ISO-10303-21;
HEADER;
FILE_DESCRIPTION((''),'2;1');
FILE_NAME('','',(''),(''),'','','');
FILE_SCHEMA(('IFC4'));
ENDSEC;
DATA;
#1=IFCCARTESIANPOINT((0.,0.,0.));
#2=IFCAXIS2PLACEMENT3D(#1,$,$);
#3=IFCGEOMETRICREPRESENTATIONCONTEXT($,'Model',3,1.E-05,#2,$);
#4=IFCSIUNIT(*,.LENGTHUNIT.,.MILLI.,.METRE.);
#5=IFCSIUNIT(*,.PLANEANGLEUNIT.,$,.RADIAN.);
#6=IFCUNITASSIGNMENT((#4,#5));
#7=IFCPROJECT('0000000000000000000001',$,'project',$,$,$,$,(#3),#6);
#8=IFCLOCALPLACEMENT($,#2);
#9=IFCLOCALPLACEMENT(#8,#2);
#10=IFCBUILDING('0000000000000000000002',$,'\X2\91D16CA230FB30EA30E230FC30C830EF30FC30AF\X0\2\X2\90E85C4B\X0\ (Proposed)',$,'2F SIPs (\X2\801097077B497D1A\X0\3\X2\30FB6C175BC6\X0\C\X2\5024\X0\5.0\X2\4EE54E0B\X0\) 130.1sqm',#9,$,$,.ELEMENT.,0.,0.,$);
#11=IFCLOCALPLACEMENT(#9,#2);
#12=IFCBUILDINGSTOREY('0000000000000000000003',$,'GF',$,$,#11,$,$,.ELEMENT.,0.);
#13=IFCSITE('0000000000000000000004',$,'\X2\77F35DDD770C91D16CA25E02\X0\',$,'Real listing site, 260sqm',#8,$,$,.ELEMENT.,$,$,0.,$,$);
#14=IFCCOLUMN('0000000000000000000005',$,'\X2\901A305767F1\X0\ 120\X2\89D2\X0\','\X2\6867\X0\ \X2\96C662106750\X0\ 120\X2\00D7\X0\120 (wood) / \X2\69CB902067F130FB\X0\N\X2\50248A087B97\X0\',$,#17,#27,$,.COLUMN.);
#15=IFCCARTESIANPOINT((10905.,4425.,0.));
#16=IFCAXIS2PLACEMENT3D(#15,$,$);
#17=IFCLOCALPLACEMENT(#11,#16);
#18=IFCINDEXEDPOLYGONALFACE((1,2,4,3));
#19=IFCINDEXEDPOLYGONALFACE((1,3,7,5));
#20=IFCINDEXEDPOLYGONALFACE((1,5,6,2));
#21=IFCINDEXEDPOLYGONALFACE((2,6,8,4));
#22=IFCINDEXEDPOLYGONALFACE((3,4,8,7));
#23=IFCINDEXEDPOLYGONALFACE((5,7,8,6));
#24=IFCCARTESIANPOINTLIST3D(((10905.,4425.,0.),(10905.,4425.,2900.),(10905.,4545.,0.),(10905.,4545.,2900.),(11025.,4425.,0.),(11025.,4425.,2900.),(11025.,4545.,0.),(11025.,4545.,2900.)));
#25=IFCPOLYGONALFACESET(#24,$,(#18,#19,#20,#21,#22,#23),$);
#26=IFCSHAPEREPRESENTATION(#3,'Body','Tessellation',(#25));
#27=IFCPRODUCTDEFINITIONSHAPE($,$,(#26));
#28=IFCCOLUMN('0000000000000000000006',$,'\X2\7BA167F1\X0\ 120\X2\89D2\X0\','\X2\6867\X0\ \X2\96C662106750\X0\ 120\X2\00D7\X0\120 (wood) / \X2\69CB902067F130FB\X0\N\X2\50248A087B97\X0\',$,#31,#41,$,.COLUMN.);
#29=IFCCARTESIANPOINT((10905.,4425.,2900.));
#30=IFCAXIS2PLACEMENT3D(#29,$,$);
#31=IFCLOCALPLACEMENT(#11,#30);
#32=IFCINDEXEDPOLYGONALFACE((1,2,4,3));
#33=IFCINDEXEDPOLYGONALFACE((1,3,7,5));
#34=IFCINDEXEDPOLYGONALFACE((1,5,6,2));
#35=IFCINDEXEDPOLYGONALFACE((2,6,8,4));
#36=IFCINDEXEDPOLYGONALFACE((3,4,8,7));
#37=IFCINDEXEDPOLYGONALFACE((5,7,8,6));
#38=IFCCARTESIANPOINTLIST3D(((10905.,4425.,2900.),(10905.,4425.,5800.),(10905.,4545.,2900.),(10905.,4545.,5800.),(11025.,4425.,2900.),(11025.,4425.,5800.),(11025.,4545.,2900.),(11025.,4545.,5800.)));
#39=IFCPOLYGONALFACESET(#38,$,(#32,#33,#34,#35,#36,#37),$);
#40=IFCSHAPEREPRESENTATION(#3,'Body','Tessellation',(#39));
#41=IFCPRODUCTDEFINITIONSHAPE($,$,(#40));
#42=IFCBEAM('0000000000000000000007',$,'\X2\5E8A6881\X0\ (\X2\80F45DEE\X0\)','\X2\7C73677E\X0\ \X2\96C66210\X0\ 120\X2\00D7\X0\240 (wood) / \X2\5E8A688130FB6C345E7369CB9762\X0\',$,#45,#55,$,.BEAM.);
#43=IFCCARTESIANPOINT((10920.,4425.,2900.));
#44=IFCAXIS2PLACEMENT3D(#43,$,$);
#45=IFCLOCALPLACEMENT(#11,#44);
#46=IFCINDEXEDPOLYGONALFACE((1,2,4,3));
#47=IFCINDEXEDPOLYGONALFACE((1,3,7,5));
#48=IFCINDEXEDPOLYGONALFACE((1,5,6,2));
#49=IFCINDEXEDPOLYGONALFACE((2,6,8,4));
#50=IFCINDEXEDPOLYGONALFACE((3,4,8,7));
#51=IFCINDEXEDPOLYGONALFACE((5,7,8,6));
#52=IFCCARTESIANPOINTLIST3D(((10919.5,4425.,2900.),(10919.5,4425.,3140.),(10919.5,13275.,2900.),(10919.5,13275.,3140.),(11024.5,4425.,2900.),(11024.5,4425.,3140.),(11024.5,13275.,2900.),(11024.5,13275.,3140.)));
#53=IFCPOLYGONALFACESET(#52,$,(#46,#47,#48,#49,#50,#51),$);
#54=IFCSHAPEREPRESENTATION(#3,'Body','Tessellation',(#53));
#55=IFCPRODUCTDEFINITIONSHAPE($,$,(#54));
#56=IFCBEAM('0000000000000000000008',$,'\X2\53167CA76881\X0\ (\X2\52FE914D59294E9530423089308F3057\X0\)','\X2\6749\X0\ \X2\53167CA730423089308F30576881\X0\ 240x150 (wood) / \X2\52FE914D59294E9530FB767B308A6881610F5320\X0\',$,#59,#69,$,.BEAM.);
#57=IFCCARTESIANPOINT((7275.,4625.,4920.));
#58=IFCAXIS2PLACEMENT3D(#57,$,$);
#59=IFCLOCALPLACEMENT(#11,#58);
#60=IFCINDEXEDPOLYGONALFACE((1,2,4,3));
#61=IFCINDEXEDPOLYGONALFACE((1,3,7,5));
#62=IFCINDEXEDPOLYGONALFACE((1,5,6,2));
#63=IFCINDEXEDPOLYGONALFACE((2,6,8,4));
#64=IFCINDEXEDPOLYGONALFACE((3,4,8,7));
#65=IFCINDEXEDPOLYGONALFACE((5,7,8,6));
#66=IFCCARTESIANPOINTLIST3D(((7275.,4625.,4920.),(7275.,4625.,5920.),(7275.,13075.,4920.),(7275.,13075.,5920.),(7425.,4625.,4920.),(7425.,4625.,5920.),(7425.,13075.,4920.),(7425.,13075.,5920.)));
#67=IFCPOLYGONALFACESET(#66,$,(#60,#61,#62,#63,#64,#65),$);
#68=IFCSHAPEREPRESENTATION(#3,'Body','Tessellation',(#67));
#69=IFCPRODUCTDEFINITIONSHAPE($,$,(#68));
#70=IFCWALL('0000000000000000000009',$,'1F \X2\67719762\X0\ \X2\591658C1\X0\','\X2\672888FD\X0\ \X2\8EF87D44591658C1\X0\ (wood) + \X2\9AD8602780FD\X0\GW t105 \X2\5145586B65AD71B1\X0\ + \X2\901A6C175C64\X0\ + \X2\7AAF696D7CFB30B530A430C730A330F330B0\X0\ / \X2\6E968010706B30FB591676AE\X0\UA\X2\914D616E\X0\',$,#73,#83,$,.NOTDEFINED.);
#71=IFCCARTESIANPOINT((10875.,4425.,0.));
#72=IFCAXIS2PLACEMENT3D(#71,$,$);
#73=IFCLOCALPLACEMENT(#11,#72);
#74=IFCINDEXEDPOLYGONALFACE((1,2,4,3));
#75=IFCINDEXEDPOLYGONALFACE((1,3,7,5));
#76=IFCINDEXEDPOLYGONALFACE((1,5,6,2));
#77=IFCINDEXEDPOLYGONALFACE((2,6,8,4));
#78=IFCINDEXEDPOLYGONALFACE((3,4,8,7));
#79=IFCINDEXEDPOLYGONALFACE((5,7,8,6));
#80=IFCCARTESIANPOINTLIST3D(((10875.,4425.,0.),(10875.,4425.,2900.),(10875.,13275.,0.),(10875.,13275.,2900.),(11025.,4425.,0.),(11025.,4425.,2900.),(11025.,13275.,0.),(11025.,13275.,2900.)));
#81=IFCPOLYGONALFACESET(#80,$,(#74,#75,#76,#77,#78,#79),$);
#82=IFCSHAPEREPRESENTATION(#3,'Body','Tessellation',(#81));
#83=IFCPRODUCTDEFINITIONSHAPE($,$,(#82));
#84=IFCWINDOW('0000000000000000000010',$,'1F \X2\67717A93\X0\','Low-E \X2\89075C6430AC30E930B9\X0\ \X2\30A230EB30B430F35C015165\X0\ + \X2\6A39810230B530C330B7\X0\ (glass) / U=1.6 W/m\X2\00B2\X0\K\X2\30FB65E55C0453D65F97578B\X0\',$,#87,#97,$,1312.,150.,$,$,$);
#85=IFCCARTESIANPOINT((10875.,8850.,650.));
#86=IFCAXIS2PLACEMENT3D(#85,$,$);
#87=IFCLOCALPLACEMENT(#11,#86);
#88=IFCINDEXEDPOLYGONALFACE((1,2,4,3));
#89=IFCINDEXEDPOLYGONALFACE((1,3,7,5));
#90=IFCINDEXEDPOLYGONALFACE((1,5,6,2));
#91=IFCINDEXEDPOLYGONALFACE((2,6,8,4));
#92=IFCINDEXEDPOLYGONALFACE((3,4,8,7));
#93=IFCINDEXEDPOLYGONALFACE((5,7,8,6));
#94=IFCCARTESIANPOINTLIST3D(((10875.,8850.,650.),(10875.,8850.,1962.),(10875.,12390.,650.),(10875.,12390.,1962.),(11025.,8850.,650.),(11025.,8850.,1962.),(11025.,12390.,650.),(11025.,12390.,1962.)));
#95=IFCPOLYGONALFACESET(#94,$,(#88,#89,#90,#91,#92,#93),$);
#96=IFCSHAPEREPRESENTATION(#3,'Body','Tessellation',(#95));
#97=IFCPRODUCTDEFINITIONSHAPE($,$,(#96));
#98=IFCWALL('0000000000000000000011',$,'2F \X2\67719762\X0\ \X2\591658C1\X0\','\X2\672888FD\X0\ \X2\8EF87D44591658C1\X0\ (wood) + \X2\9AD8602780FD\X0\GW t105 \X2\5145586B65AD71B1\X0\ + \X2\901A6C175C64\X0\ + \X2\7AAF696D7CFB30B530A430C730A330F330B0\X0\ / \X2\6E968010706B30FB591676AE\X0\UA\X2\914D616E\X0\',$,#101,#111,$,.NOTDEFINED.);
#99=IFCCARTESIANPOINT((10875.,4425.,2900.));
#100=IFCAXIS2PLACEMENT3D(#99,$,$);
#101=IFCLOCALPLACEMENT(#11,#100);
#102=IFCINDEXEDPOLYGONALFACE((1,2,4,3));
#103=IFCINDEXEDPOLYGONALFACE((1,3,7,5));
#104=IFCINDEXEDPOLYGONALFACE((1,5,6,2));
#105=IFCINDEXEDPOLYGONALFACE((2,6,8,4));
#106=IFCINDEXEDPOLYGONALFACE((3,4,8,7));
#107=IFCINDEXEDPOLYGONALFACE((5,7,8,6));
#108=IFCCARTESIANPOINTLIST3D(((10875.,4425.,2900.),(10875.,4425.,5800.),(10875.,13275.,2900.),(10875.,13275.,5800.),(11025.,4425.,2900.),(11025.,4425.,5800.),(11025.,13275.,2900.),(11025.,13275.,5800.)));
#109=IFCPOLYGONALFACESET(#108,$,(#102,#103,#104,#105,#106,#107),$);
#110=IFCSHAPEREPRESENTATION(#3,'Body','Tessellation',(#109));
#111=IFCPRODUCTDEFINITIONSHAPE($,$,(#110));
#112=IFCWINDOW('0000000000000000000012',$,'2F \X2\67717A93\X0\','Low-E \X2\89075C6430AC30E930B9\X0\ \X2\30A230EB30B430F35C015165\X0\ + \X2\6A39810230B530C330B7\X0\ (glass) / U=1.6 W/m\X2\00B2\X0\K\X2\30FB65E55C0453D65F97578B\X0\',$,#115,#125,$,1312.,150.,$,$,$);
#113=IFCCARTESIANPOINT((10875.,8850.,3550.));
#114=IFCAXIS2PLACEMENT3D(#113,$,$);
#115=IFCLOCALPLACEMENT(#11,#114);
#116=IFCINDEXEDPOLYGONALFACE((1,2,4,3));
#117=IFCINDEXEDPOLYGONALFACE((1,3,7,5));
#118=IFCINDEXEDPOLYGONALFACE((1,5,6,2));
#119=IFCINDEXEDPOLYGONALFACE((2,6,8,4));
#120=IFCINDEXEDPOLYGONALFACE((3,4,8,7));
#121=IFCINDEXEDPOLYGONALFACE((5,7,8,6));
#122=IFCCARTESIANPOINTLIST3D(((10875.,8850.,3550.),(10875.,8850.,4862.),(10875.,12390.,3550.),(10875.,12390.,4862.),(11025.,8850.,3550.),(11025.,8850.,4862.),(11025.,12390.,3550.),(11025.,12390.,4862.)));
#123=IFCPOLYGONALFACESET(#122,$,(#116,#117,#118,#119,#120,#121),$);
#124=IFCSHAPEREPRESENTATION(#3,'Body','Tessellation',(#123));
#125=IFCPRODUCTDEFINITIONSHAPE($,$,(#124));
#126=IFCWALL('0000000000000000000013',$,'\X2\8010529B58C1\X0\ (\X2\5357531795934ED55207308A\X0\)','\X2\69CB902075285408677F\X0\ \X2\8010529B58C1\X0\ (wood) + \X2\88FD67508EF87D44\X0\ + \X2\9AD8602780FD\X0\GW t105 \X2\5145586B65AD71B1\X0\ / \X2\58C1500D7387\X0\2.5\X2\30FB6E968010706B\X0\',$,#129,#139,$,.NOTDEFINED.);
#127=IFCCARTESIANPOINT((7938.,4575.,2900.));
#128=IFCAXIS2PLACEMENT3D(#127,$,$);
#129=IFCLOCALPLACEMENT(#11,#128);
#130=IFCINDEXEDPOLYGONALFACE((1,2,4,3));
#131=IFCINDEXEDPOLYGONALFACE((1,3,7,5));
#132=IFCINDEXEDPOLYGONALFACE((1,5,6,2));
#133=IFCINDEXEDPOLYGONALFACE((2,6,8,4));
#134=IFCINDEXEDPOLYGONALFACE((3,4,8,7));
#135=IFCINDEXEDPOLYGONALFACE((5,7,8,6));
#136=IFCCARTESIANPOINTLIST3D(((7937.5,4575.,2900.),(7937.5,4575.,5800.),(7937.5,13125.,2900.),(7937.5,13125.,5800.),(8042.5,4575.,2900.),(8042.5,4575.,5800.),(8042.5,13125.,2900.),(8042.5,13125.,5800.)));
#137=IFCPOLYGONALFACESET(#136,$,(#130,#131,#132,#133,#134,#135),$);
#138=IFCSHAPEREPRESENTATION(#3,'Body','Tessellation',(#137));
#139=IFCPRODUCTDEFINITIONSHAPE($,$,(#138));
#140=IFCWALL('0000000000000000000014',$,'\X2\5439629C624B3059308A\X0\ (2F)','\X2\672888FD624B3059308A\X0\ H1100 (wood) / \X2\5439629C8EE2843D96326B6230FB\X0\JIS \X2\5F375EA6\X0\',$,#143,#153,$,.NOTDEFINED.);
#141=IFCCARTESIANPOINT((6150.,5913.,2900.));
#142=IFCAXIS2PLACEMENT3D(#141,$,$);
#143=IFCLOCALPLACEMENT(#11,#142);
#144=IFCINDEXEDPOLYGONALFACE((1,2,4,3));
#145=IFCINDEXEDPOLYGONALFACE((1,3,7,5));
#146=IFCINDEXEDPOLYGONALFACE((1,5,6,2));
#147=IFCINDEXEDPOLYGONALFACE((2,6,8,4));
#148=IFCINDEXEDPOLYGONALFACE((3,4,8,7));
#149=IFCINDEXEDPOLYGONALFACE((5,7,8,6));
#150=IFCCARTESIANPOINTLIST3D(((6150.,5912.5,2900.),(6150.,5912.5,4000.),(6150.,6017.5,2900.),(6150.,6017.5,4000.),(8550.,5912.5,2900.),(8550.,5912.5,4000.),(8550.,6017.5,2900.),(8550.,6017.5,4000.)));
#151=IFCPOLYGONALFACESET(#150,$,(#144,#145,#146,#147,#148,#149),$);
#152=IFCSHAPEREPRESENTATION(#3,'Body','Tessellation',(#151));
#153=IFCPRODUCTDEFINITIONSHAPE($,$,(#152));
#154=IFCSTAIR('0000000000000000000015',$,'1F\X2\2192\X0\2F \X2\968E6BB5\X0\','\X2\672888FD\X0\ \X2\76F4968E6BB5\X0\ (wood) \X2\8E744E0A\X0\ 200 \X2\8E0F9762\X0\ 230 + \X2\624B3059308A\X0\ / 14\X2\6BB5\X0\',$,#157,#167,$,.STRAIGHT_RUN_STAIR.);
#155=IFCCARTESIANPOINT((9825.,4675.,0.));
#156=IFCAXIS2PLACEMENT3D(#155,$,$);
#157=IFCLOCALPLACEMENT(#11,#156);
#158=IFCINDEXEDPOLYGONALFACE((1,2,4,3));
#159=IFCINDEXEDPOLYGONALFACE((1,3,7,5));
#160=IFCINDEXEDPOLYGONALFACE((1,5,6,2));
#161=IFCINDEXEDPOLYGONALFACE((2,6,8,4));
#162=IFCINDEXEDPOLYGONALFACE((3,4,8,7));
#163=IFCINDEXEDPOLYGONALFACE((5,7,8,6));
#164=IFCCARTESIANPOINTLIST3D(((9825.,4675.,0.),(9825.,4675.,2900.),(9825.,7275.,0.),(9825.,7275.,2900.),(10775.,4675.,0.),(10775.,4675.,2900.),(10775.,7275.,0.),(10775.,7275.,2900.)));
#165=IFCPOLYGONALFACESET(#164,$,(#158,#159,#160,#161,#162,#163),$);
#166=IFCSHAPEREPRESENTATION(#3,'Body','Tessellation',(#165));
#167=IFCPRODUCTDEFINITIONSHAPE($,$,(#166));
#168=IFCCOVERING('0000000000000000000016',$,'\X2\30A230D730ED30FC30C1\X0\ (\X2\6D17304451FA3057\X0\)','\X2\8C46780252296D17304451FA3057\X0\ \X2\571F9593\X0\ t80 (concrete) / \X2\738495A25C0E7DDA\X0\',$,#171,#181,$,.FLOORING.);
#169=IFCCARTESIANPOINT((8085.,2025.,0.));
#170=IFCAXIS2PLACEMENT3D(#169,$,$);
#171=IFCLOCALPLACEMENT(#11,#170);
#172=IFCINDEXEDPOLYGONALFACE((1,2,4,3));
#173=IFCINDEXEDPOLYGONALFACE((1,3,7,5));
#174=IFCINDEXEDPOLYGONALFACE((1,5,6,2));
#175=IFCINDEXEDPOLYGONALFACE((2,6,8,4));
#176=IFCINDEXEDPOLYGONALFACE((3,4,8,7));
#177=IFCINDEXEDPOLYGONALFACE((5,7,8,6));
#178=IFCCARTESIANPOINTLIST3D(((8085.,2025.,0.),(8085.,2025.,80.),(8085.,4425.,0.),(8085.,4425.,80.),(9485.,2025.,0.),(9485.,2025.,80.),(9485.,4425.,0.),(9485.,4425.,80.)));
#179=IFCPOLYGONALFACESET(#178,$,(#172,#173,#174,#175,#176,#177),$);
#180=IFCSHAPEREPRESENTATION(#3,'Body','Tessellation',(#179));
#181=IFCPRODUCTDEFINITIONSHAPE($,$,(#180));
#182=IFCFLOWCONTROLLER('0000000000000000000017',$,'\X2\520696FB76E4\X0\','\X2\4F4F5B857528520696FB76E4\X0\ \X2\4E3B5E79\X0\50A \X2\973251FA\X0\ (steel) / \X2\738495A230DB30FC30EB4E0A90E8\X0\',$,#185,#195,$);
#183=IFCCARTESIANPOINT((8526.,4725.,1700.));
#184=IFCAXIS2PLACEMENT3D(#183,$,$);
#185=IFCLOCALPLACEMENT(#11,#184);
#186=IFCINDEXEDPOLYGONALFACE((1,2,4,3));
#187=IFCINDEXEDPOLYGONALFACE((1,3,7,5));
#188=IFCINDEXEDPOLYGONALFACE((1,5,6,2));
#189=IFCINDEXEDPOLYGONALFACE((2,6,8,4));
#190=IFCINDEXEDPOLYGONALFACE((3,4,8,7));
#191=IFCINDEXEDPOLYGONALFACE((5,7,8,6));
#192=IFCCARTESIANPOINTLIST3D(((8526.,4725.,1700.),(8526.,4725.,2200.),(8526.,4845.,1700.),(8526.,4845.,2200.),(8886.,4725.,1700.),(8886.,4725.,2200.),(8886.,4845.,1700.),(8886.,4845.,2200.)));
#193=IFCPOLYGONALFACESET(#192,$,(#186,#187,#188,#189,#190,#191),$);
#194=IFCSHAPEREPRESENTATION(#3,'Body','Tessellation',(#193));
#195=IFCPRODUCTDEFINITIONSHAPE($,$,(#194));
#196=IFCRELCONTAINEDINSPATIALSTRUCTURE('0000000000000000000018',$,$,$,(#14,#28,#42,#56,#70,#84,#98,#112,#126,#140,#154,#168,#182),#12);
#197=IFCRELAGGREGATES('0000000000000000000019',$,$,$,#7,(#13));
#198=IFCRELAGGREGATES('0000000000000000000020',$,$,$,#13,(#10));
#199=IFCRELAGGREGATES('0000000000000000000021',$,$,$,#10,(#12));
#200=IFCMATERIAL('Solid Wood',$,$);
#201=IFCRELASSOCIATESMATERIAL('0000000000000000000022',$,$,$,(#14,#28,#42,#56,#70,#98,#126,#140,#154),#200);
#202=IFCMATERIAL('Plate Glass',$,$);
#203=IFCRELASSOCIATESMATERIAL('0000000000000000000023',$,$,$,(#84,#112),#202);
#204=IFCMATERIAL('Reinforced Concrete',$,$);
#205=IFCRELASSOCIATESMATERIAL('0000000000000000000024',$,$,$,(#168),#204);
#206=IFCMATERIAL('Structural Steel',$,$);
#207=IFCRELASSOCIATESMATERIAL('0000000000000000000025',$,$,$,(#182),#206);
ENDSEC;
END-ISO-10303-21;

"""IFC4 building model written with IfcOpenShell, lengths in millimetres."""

from ifc_helpers import new_model, si_unit, frame, frame_2d, origin, place, context, project, spatial, rectangle, extrude, material, element, fill, save


model = new_model("IFC4")

# Units and contexts
model_context = context("Model", 3, precision=1e-05, world=origin())
ifc_project = project(units=[si_unit("LENGTHUNIT", "METRE", prefix="MILLI"), si_unit("PLANEANGLEUNIT", "RADIAN")], contexts=[model_context])

# Site, building, storey
site_placement = place(None, origin())
site = spatial("IfcSite", under=ifc_project, at=site_placement, Name="石川県金沢市", ObjectType="Real listing site, 260sqm", CompositionType="ELEMENT", RefElevation=0.0)
building_placement = place(site_placement, origin())
building = spatial("IfcBuilding", under=site, at=building_placement, Name="金沢・リモートワーク2部屋 (Proposed)", ObjectType="2F SIPs (耐震等級3・気密C値5.0以下) 130.1sqm", CompositionType="ELEMENT", ElevationOfRefHeight=0.0, ElevationOfTerrain=0.0)
storey_placement = place(building_placement, origin())
storey = spatial("IfcBuildingStorey", under=building, at=storey_placement, Name="GF", CompositionType="ELEMENT", Elevation=0.0)

# Columns
ifc_material_1 = material(Name="Solid Wood")
column_1_placement = place(storey_placement, frame((10905.0, 4425.0, 0.0)))
element("IfcColumn", 1, at=column_1_placement, inside=storey, material=ifc_material_1, Name="通し柱 120角", Description="桧 集成材 120×120 (wood) / 構造柱・N値計算", PredefinedType="COLUMN", context=model_context, shape_type="SweptSolid", body=[
    extrude(rectangle(XDim=120.0, YDim=120.0, at=frame_2d((60.0, 60.0))), frame((10905.0, 4425.0, 0.0)), (0.0, 0.0, 1.0), 2900.0),
])
column_2_placement = place(storey_placement, frame((10905.0, 4425.0, 2900.0)))
element("IfcColumn", 2, at=column_2_placement, inside=storey, material=ifc_material_1, Name="管柱 120角", Description="桧 集成材 120×120 (wood) / 構造柱・N値計算", PredefinedType="COLUMN", context=model_context, shape_type="SweptSolid", body=[
    extrude(rectangle(XDim=120.0, YDim=120.0, at=frame_2d((60.0, 60.0))), frame((10905.0, 4425.0, 2900.0)), (0.0, 0.0, 1.0), 2900.0),
])

# Beams
beam_1_placement = place(storey_placement, frame((10920.0, 4425.0, 2900.0)))
element("IfcBeam", 3, at=beam_1_placement, inside=storey, material=ifc_material_1, Name="床梁 (胴差)", Description="米松 集成 120×240 (wood) / 床梁・水平構面", PredefinedType="BEAM", context=model_context, shape_type="SweptSolid", body=[
    extrude(rectangle(XDim=105.0, YDim=8850.0, at=frame_2d((52.0, 4425.0))), frame((10920.0, 4425.0, 2900.0)), (0.0, 0.0, 1.0), 240.0),
])
beam_2_placement = place(storey_placement, frame((7275.0, 4625.0, 4920.0)))
element("IfcBeam", 4, at=beam_2_placement, inside=storey, material=ifc_material_1, Name="化粧梁 (勾配天井あらわし)", Description="杉 化粧あらわし梁 240x150 (wood) / 勾配天井・登り梁意匠", PredefinedType="BEAM", context=model_context, shape_type="SweptSolid", body=[
    extrude(rectangle(XDim=150.0, YDim=8450.0, at=frame_2d((75.0, 4225.0))), frame((7275.0, 4625.0, 4920.0)), (0.0, 0.0, 1.0), 1000.0),
])

# Wall, opening, window
wall_1_placement = place(storey_placement, frame((10875.0, 4425.0, 0.0)))
wall_1 = element("IfcWall", 5, at=wall_1_placement, inside=storey, material=ifc_material_1, Name="1F 東面 外壁", Description="木製 軸組外壁 (wood) + 高性能GW t105 充填断熱 + 通気層 + 窯業系サイディング / 準耐火・外皮UA配慮", PredefinedType="NOTDEFINED", context=model_context, shape_type="SweptSolid", body=[
    extrude(rectangle(XDim=150.0, YDim=8850.0, at=frame_2d((75.0, 4425.0))), frame((10875.0, 4425.0, 0.0)), (0.0, 0.0, 1.0), 2900.0),
])
opening_1_placement = place(storey_placement, frame((10875.0, 8850.0, 650.0)))
opening_1 = element("IfcOpeningElement", 6, at=opening_1_placement, cuts=wall_1, PredefinedType="NOTDEFINED", context=model_context, shape_type="SweptSolid", body=[
    extrude(rectangle(XDim=150.0, YDim=3540.0, at=frame_2d((75.0, 1770.0))), frame((10875.0, 8850.0, 650.0)), (0.0, 0.0, 1.0), 1312.0),
])
ifc_material_2 = material(Name="Plate Glass")
window_1_placement = place(storey_placement, frame((10875.0, 8850.0, 650.0)))
window_1 = element("IfcWindow", 7, at=window_1_placement, inside=storey, material=ifc_material_2, Name="1F 東窓", Description="Low-E 複層ガラス アルゴン封入 + 樹脂サッシ (glass) / U=1.6 W/m²K・日射取得型", OverallHeight=1312.0, OverallWidth=150.0, context=model_context, shape_type="SweptSolid", body=[
    extrude(rectangle(XDim=150.0, YDim=3540.0, at=frame_2d((75.0, 1770.0))), frame((10875.0, 8850.0, 650.0)), (0.0, 0.0, 1.0), 1312.0),
])
fill(opening_1, window_1)

# Wall, opening, window
wall_2_placement = place(storey_placement, frame((10875.0, 4425.0, 2900.0)))
wall_2 = element("IfcWall", 8, at=wall_2_placement, inside=storey, material=ifc_material_1, Name="2F 東面 外壁", Description="木製 軸組外壁 (wood) + 高性能GW t105 充填断熱 + 通気層 + 窯業系サイディング / 準耐火・外皮UA配慮", PredefinedType="NOTDEFINED", context=model_context, shape_type="SweptSolid", body=[
    extrude(rectangle(XDim=150.0, YDim=8850.0, at=frame_2d((75.0, 4425.0))), frame((10875.0, 4425.0, 2900.0)), (0.0, 0.0, 1.0), 2900.0),
])
opening_2_placement = place(storey_placement, frame((10875.0, 8850.0, 3550.0)))
opening_2 = element("IfcOpeningElement", 9, at=opening_2_placement, cuts=wall_2, PredefinedType="NOTDEFINED", context=model_context, shape_type="SweptSolid", body=[
    extrude(rectangle(XDim=150.0, YDim=3540.0, at=frame_2d((75.0, 1770.0))), frame((10875.0, 8850.0, 3550.0)), (0.0, 0.0, 1.0), 1312.0),
])
window_2_placement = place(storey_placement, frame((10875.0, 8850.0, 3550.0)))
window_2 = element("IfcWindow", 10, at=window_2_placement, inside=storey, material=ifc_material_2, Name="2F 東窓", Description="Low-E 複層ガラス アルゴン封入 + 樹脂サッシ (glass) / U=1.6 W/m²K・日射取得型", OverallHeight=1312.0, OverallWidth=150.0, context=model_context, shape_type="SweptSolid", body=[
    extrude(rectangle(XDim=150.0, YDim=3540.0, at=frame_2d((75.0, 1770.0))), frame((10875.0, 8850.0, 3550.0)), (0.0, 0.0, 1.0), 1312.0),
])
fill(opening_2, window_2)

# Walls
wall_3_placement = place(storey_placement, frame((7938.0, 4575.0, 2900.0)))
element("IfcWall", 11, at=wall_3_placement, inside=storey, material=ifc_material_1, Name="耐力壁 (南北間仕切り)", Description="構造用合板 耐力壁 (wood) + 製材軸組 + 高性能GW t105 充填断熱 / 壁倍率2.5・準耐火", PredefinedType="NOTDEFINED", context=model_context, shape_type="SweptSolid", body=[
    extrude(rectangle(XDim=105.0, YDim=8550.0, at=frame_2d((52.0, 4275.0))), frame((7938.0, 4575.0, 2900.0)), (0.0, 0.0, 1.0), 2900.0),
])
wall_4_placement = place(storey_placement, frame((6150.0, 5913.0, 2900.0)))
element("IfcWall", 12, at=wall_4_placement, inside=storey, material=ifc_material_1, Name="吹抜手すり (2F)", Description="木製手すり H1100 (wood) / 吹抜転落防止・JIS 強度", PredefinedType="NOTDEFINED", context=model_context, shape_type="SweptSolid", body=[
    extrude(rectangle(XDim=2400.0, YDim=105.0, at=frame_2d((1200.0, 52.0))), frame((6150.0, 5913.0, 2900.0)), (0.0, 0.0, 1.0), 1100.0),
])

# Stair
stair_placement = place(storey_placement, frame((9825.0, 4675.0, 0.0)))
element("IfcStair", 13, at=stair_placement, inside=storey, material=ifc_material_1, Name="1F→2F 階段", Description="木製 直階段 (wood) 蹴上 200 踏面 230 + 手すり / 14段", PredefinedType="STRAIGHT_RUN_STAIR", context=model_context, shape_type="SweptSolid", body=[
    extrude(rectangle(XDim=950.0, YDim=2600.0, at=frame_2d((475.0, 1300.0))), frame((9825.0, 4675.0, 0.0)), (0.0, 0.0, 1.0), 2900.0),
])

# Covering
ifc_material_3 = material(Name="Reinforced Concrete")
covering_placement = place(storey_placement, frame((8085.0, 2025.0, 0.0)))
element("IfcCovering", 14, at=covering_placement, inside=storey, material=ifc_material_3, Name="アプローチ (洗い出し)", Description="豆砂利洗い出し 土間 t80 (concrete) / 玄関導線", PredefinedType="FLOORING", context=model_context, shape_type="SweptSolid", body=[
    extrude(rectangle(XDim=1400.0, YDim=2400.0, at=frame_2d((700.0, 1200.0))), frame((8085.0, 2025.0, 0.0)), (0.0, 0.0, 1.0), 80.0),
])

# Flow controller
ifc_material_4 = material(Name="Structural Steel")
flow_controller_placement = place(storey_placement, frame((8526.0, 4725.0, 1700.0)))
element("IfcFlowController", 15, at=flow_controller_placement, inside=storey, material=ifc_material_4, Name="分電盤", Description="住宅用分電盤 主幹50A 露出 (steel) / 玄関ホール上部", context=model_context, shape_type="SweptSolid", body=[
    extrude(rectangle(XDim=360.0, YDim=120.0, at=frame_2d((180.0, 60.0))), frame((8526.0, 4725.0, 1700.0)), (0.0, 0.0, 1.0), 500.0),
])

save(model, "model.ifc")
